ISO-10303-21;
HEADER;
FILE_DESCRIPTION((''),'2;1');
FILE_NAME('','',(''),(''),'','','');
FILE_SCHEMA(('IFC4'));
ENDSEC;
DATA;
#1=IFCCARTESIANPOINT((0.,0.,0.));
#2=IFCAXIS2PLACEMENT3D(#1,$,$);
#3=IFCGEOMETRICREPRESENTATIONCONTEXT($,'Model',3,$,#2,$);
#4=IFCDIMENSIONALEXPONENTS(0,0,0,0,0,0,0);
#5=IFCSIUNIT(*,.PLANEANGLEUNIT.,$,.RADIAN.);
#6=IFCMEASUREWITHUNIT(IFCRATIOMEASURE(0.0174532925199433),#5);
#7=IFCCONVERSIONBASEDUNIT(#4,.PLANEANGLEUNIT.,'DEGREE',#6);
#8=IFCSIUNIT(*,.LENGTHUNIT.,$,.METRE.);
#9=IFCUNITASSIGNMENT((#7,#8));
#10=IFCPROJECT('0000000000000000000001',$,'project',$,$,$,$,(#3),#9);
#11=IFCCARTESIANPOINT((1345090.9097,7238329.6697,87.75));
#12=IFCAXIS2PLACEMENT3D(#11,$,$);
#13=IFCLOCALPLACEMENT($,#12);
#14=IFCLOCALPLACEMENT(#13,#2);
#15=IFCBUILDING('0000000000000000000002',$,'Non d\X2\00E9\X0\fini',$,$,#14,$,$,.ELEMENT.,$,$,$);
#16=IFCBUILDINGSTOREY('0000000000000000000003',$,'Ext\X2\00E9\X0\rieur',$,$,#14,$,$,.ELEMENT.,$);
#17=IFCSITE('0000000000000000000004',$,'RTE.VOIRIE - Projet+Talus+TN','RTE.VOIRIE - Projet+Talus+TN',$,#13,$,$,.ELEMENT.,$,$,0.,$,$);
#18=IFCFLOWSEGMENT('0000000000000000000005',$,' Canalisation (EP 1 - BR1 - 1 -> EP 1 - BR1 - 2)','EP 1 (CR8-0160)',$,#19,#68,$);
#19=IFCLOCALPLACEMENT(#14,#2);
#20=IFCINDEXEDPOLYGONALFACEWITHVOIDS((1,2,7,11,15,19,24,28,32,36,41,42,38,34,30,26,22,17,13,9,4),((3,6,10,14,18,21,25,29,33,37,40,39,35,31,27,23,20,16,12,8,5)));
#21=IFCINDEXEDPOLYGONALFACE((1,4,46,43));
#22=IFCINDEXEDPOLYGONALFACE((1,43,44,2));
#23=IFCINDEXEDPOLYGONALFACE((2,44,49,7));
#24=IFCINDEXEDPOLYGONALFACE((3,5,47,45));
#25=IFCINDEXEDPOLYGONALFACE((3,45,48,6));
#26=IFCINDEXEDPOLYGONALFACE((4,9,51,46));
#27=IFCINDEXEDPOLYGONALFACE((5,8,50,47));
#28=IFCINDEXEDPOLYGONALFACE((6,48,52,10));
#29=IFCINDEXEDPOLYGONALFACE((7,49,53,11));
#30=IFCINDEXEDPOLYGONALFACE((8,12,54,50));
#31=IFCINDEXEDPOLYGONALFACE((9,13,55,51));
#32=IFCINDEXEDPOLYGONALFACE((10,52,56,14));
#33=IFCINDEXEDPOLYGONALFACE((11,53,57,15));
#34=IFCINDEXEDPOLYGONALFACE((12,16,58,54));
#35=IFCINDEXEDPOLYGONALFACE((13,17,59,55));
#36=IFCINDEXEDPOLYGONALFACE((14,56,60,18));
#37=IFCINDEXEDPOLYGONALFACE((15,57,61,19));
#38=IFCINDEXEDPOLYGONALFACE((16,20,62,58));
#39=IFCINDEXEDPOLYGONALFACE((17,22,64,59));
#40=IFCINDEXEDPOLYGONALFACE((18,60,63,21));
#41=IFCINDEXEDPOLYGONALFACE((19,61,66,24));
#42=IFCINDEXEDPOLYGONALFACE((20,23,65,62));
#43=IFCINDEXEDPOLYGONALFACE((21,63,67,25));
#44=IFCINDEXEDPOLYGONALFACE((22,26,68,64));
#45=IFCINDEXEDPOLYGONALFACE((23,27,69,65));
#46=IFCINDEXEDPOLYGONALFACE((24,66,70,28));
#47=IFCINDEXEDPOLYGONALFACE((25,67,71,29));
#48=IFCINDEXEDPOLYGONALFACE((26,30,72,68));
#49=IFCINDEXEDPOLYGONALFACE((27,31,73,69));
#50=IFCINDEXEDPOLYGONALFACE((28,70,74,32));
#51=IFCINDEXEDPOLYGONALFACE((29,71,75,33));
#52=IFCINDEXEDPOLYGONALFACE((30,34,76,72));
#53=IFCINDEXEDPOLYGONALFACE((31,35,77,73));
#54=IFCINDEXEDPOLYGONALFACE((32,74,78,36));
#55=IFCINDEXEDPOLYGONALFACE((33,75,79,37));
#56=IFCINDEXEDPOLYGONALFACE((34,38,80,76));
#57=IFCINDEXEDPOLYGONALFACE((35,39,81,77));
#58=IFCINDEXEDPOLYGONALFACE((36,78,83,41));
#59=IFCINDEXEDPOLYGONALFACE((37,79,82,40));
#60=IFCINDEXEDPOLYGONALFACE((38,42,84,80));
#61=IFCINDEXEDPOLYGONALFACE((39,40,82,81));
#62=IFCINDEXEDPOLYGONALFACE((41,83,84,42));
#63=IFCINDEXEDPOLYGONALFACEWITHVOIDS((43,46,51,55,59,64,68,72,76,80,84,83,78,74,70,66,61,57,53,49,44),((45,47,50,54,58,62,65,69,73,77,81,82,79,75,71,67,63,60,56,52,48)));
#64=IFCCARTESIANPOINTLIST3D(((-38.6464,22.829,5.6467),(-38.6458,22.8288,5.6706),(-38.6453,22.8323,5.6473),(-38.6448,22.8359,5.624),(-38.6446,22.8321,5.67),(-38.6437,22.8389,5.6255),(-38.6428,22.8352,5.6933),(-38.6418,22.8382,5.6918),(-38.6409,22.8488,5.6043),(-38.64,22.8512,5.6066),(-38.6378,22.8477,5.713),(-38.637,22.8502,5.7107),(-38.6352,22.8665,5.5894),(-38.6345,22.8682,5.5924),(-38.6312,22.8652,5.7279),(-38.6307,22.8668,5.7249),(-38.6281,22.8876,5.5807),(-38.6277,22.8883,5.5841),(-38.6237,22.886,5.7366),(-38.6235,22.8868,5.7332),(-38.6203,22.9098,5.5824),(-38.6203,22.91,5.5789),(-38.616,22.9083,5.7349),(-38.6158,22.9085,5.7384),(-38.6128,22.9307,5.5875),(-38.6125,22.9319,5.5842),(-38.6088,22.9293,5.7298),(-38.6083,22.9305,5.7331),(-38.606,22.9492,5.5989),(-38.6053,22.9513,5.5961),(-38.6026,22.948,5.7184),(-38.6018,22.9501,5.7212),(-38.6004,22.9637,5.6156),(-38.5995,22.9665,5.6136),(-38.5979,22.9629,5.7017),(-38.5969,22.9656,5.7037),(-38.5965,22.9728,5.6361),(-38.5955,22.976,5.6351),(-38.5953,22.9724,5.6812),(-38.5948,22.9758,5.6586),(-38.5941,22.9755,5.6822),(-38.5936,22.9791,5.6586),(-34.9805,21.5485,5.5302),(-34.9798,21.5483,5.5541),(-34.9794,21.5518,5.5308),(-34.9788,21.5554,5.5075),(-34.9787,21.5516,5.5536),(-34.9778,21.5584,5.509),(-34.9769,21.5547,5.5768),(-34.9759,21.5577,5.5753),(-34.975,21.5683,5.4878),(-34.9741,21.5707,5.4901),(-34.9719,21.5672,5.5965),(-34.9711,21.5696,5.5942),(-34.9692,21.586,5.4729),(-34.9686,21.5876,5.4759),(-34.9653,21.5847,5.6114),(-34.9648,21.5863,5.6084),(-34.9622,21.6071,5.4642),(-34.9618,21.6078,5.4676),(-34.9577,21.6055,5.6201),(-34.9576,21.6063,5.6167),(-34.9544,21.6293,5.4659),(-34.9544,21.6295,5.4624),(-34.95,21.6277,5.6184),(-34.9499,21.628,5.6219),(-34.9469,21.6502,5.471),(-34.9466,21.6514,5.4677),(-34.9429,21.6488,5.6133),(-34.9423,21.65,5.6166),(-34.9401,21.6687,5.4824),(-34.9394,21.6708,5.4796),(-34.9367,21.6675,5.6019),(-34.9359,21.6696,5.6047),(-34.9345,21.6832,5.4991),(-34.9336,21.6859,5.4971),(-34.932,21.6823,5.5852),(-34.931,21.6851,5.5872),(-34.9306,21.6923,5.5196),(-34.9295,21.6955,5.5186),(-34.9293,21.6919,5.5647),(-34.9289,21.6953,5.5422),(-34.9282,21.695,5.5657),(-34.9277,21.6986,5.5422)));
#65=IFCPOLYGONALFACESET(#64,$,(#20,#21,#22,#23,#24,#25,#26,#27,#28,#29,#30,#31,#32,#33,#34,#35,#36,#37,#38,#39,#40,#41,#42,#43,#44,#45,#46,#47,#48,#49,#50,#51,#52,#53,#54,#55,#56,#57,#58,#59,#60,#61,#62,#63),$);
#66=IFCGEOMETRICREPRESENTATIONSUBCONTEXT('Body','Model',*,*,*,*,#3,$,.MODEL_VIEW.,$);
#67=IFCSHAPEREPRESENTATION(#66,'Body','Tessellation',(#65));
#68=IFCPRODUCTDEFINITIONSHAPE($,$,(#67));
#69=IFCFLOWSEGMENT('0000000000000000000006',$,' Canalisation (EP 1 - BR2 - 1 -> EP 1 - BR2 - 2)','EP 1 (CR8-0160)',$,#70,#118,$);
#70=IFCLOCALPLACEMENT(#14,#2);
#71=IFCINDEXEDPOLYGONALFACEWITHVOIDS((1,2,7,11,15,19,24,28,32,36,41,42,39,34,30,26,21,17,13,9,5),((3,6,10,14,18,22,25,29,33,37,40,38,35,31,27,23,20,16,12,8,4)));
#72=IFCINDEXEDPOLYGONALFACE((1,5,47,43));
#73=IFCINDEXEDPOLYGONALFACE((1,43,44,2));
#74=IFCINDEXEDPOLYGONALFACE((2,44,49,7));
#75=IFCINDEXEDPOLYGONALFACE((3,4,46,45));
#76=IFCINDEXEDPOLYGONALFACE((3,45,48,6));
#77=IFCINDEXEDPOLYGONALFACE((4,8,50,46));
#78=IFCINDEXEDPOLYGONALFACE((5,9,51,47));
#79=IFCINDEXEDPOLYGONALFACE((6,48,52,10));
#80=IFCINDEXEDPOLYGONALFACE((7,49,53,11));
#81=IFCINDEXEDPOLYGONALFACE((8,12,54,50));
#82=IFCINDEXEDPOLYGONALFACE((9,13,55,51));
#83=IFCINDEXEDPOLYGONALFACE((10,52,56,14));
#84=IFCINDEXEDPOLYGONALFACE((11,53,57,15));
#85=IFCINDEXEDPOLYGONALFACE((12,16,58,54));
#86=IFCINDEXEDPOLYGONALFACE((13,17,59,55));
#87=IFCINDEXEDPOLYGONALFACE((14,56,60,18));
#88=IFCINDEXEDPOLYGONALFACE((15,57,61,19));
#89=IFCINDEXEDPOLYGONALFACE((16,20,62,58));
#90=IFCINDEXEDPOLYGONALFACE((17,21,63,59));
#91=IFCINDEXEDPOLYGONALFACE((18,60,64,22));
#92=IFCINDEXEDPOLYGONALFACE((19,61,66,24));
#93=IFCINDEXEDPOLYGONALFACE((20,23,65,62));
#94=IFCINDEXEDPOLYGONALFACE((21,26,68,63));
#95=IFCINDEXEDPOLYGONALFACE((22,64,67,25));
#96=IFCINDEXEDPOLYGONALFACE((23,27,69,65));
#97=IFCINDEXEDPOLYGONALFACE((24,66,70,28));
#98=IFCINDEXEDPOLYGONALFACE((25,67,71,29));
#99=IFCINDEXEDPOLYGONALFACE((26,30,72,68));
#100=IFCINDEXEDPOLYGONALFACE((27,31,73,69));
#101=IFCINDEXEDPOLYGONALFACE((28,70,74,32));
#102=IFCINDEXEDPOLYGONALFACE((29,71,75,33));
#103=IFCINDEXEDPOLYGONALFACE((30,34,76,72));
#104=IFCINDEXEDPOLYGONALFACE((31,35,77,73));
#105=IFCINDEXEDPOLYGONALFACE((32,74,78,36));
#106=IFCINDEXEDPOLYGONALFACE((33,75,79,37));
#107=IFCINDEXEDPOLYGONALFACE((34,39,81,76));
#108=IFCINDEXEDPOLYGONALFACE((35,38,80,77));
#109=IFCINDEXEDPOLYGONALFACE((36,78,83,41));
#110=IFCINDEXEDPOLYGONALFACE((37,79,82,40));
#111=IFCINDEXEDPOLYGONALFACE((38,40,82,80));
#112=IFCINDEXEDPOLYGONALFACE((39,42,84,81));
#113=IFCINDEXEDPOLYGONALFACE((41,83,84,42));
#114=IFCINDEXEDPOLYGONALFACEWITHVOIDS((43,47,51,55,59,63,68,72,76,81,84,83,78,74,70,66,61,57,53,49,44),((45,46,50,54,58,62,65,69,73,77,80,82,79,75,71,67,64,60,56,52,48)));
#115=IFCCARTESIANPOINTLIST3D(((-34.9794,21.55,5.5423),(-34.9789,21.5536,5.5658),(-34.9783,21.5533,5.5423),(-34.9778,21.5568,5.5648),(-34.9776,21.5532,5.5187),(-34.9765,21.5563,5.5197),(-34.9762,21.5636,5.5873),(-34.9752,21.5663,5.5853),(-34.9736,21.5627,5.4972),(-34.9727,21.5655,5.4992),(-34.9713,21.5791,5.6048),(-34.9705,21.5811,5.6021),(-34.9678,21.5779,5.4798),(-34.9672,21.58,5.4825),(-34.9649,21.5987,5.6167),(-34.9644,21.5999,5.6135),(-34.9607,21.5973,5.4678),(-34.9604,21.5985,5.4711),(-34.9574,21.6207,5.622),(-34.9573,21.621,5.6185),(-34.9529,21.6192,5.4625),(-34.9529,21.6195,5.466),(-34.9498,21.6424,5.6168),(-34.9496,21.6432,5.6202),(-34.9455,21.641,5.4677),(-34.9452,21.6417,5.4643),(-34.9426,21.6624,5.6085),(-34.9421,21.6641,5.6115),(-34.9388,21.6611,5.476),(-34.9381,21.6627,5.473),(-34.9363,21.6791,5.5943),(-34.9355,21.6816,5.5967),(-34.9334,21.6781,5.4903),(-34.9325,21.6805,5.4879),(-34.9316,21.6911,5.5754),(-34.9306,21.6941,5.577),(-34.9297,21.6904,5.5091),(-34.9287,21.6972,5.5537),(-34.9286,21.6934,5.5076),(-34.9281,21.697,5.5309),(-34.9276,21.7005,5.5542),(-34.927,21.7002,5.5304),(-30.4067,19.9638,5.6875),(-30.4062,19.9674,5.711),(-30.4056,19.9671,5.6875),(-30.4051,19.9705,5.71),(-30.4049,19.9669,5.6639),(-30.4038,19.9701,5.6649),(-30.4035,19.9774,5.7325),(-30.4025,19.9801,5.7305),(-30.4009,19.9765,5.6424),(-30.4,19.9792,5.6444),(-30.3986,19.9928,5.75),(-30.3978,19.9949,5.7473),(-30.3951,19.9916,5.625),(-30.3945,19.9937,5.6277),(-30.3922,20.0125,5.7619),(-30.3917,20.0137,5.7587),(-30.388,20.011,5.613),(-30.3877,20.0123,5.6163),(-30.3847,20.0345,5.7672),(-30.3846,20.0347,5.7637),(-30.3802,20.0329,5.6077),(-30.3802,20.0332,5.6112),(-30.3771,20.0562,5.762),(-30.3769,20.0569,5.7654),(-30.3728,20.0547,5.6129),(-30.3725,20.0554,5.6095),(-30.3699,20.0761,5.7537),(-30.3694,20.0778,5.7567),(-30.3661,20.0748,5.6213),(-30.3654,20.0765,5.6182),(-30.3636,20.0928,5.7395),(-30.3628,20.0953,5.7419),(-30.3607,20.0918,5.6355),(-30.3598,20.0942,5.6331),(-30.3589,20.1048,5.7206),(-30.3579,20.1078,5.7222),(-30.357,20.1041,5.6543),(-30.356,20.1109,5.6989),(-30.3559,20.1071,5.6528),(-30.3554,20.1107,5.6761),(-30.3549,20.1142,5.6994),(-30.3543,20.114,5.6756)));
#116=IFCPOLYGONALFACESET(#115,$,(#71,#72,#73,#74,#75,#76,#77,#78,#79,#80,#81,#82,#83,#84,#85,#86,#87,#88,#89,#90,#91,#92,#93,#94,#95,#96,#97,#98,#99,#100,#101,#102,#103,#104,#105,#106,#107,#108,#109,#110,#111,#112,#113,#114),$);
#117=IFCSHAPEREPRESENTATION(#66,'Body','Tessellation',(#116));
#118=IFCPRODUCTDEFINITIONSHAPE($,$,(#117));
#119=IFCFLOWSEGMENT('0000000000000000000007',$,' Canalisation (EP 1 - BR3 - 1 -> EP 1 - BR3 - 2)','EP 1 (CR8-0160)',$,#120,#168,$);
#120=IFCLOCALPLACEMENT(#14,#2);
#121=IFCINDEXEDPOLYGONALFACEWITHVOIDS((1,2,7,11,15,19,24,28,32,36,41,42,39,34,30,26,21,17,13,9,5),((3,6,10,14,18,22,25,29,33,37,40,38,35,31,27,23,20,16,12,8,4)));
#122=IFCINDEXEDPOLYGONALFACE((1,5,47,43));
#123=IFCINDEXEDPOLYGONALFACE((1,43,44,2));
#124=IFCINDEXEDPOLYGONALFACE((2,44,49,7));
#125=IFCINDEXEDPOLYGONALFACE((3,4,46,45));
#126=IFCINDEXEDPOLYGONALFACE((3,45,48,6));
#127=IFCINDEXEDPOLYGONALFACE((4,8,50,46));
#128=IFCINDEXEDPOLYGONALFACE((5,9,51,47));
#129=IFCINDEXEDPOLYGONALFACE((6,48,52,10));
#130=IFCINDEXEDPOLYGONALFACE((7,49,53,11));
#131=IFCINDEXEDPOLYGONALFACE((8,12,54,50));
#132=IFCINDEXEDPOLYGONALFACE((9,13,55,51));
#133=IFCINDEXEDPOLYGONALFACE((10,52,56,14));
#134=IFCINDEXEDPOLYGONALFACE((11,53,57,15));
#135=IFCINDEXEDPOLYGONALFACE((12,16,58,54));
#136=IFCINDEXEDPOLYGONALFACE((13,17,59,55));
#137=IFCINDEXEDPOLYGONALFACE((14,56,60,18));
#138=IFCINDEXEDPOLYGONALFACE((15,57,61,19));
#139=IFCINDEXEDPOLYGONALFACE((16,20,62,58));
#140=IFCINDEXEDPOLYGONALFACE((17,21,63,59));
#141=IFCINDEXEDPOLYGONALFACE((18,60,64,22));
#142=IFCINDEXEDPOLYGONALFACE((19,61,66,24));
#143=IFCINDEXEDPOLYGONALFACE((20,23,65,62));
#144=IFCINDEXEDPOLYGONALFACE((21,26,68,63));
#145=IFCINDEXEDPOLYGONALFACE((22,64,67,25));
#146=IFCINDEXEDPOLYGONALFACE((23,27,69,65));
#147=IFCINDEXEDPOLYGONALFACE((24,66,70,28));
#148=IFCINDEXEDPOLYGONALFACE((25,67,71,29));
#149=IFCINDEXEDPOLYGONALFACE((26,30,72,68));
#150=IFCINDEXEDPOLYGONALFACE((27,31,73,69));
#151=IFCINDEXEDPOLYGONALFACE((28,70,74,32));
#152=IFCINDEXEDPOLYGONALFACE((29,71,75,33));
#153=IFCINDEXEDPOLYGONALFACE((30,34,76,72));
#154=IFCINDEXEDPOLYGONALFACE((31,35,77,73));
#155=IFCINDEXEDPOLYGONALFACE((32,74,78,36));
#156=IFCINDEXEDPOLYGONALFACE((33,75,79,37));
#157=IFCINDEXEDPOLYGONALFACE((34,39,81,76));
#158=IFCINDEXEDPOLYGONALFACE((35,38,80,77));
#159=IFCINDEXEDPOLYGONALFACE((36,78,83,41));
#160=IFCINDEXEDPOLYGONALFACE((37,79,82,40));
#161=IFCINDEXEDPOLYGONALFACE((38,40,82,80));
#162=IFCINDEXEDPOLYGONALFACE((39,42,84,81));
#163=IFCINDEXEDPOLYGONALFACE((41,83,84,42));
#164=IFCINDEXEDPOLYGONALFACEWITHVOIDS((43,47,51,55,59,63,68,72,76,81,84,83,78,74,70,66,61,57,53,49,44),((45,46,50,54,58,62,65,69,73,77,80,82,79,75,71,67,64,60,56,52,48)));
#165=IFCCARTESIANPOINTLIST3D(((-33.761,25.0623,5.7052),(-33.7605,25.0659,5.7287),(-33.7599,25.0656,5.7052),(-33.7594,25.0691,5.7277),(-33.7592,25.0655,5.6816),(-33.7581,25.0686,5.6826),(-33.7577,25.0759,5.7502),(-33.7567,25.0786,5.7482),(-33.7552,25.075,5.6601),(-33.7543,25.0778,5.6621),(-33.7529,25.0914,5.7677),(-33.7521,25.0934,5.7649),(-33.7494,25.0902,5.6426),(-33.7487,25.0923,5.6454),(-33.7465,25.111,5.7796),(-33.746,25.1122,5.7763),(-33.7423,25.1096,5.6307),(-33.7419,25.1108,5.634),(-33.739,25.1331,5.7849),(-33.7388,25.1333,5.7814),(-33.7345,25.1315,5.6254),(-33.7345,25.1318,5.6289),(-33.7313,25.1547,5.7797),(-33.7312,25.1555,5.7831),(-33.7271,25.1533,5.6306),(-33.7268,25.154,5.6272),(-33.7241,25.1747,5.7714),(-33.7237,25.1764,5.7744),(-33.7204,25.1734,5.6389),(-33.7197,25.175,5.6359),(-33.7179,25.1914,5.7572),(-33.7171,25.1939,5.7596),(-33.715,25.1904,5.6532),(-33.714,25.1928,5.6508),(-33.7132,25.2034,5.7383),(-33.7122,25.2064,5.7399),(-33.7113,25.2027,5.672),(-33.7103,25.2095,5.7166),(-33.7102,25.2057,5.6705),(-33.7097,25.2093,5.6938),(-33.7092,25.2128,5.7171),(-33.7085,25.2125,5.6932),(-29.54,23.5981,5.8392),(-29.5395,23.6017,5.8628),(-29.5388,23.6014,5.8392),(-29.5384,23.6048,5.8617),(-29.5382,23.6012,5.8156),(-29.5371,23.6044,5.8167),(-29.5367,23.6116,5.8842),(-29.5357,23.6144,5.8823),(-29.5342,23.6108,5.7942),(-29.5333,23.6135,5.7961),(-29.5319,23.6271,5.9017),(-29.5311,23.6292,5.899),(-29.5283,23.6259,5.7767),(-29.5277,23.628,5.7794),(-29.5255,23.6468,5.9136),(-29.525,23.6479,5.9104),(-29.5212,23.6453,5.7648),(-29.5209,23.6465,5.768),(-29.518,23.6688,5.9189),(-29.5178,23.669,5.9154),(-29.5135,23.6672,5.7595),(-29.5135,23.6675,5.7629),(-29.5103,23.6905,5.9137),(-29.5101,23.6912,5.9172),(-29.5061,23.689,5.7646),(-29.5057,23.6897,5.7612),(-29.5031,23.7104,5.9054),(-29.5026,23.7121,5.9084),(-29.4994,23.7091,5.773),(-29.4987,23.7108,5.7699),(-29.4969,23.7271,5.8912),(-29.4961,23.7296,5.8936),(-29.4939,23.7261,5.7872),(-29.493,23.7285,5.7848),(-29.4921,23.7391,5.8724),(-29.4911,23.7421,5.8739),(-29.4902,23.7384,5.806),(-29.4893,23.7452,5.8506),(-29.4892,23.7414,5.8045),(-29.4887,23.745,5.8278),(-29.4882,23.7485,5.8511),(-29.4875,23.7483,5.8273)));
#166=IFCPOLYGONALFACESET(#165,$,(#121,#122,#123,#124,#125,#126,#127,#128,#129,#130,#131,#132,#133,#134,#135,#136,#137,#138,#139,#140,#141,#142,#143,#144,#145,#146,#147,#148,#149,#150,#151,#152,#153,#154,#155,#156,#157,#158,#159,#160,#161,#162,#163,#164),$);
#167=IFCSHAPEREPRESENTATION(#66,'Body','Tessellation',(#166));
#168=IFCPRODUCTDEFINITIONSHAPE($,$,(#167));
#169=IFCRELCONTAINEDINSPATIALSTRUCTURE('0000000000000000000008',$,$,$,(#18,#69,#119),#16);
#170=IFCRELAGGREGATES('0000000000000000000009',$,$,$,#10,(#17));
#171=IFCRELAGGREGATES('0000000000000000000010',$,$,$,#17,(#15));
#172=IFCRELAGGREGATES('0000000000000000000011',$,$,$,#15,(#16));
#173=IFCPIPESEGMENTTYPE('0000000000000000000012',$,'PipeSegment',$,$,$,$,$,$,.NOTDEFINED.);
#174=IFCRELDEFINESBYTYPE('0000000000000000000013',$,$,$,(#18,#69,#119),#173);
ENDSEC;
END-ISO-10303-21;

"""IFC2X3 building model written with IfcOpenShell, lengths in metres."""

from ifc_helpers import new_model, entity, si_unit, converted_unit, frame, origin, origin_2d_with_axis, place, context, subcontext, project, spatial, hollow_circle, extrude, type_object, element, save


model = new_model("IFC2X3")

# Units and contexts
model_context = context("Model", 3, world=origin())
body_context = subcontext(model_context, "Body", "Model", "MODEL_VIEW")
ifc_project = project(units=[converted_unit("PLANEANGLEUNIT", "DEGREE", entity("IfcRatioMeasure", 0.0174532925199433), si_unit("PLANEANGLEUNIT", "RADIAN"), dimensions=[0, 0, 0, 0, 0, 0, 0]), si_unit("LENGTHUNIT", "METRE")], contexts=[model_context])

# Site, building, storey
site_placement = place(None, frame((1345090.9097, 7238329.6697, 87.75)))
site = spatial("IfcSite", under=ifc_project, at=site_placement, Name="RTE.VOIRIE - Projet+Talus+TN", Description="RTE.VOIRIE - Projet+Talus+TN", CompositionType="ELEMENT", RefElevation=0.0)
placement = place(site_placement, origin())
building = spatial("IfcBuilding", under=site, at=placement, Name="Non défini", CompositionType="ELEMENT")
storey = spatial("IfcBuildingStorey", under=building, at=placement, Name="Extérieur", CompositionType="ELEMENT")

# Flow segments
pipe_segment_type_1 = type_object("IfcPipeSegmentType", Name="PipeSegment", PredefinedType="NOTDEFINED")
flow_segment_1_placement = place(placement, origin())
element("IfcFlowSegment", 1, at=flow_segment_1_placement, inside=storey, type_object=pipe_segment_type_1, Name=" Canalisation (EP 1 - BR1 - 1 -> EP 1 - BR1 - 2)", Description="EP 1 (CR8-0160)", context=body_context, shape_type="SweptSolid", body=[
    extrude(hollow_circle(Radius=0.08, WallThickness=0.0035, at=origin_2d_with_axis()), frame((-38.62, 22.9036, 5.6586), z_axis=(0.94364, -0.329614, -0.029987), x_axis=(0.329614, 0.94364, 0.0)), (0.0, 0.0, 1.0), 3.8849),
])
flow_segment_2_placement = place(placement, origin())
element("IfcFlowSegment", 2, at=flow_segment_2_placement, inside=storey, type_object=pipe_segment_type_1, Name=" Canalisation (EP 1 - BR2 - 1 -> EP 1 - BR2 - 2)", Description="EP 1 (CR8-0160)", context=body_context, shape_type="SweptSolid", body=[
    extrude(hollow_circle(Radius=0.08, WallThickness=0.0035, at=origin_2d_with_axis()), frame((-30.3805, 20.0394, 5.6875), z_axis=(-0.944344, 0.32759, -0.029987), x_axis=(-0.32759, -0.944344, 0.0)), (0.0, 0.0, 1.0), 4.8422),
])
flow_segment_3_placement = place(placement, origin())
element("IfcFlowSegment", 3, at=flow_segment_3_placement, inside=storey, type_object=pipe_segment_type_1, Name=" Canalisation (EP 1 - BR3 - 1 -> EP 1 - BR3 - 2)", Description="EP 1 (CR8-0160)", context=body_context, shape_type="SweptSolid", body=[
    extrude(hollow_circle(Radius=0.08, WallThickness=0.0035, at=origin_2d_with_axis()), frame((-29.5138, 23.6737, 5.8392), z_axis=(-0.944344, 0.32759, -0.029987), x_axis=(-0.32759, -0.944344, 0.0)), (0.0, 0.0, 1.0), 4.4698),
])

save(model, "model.ifc")
